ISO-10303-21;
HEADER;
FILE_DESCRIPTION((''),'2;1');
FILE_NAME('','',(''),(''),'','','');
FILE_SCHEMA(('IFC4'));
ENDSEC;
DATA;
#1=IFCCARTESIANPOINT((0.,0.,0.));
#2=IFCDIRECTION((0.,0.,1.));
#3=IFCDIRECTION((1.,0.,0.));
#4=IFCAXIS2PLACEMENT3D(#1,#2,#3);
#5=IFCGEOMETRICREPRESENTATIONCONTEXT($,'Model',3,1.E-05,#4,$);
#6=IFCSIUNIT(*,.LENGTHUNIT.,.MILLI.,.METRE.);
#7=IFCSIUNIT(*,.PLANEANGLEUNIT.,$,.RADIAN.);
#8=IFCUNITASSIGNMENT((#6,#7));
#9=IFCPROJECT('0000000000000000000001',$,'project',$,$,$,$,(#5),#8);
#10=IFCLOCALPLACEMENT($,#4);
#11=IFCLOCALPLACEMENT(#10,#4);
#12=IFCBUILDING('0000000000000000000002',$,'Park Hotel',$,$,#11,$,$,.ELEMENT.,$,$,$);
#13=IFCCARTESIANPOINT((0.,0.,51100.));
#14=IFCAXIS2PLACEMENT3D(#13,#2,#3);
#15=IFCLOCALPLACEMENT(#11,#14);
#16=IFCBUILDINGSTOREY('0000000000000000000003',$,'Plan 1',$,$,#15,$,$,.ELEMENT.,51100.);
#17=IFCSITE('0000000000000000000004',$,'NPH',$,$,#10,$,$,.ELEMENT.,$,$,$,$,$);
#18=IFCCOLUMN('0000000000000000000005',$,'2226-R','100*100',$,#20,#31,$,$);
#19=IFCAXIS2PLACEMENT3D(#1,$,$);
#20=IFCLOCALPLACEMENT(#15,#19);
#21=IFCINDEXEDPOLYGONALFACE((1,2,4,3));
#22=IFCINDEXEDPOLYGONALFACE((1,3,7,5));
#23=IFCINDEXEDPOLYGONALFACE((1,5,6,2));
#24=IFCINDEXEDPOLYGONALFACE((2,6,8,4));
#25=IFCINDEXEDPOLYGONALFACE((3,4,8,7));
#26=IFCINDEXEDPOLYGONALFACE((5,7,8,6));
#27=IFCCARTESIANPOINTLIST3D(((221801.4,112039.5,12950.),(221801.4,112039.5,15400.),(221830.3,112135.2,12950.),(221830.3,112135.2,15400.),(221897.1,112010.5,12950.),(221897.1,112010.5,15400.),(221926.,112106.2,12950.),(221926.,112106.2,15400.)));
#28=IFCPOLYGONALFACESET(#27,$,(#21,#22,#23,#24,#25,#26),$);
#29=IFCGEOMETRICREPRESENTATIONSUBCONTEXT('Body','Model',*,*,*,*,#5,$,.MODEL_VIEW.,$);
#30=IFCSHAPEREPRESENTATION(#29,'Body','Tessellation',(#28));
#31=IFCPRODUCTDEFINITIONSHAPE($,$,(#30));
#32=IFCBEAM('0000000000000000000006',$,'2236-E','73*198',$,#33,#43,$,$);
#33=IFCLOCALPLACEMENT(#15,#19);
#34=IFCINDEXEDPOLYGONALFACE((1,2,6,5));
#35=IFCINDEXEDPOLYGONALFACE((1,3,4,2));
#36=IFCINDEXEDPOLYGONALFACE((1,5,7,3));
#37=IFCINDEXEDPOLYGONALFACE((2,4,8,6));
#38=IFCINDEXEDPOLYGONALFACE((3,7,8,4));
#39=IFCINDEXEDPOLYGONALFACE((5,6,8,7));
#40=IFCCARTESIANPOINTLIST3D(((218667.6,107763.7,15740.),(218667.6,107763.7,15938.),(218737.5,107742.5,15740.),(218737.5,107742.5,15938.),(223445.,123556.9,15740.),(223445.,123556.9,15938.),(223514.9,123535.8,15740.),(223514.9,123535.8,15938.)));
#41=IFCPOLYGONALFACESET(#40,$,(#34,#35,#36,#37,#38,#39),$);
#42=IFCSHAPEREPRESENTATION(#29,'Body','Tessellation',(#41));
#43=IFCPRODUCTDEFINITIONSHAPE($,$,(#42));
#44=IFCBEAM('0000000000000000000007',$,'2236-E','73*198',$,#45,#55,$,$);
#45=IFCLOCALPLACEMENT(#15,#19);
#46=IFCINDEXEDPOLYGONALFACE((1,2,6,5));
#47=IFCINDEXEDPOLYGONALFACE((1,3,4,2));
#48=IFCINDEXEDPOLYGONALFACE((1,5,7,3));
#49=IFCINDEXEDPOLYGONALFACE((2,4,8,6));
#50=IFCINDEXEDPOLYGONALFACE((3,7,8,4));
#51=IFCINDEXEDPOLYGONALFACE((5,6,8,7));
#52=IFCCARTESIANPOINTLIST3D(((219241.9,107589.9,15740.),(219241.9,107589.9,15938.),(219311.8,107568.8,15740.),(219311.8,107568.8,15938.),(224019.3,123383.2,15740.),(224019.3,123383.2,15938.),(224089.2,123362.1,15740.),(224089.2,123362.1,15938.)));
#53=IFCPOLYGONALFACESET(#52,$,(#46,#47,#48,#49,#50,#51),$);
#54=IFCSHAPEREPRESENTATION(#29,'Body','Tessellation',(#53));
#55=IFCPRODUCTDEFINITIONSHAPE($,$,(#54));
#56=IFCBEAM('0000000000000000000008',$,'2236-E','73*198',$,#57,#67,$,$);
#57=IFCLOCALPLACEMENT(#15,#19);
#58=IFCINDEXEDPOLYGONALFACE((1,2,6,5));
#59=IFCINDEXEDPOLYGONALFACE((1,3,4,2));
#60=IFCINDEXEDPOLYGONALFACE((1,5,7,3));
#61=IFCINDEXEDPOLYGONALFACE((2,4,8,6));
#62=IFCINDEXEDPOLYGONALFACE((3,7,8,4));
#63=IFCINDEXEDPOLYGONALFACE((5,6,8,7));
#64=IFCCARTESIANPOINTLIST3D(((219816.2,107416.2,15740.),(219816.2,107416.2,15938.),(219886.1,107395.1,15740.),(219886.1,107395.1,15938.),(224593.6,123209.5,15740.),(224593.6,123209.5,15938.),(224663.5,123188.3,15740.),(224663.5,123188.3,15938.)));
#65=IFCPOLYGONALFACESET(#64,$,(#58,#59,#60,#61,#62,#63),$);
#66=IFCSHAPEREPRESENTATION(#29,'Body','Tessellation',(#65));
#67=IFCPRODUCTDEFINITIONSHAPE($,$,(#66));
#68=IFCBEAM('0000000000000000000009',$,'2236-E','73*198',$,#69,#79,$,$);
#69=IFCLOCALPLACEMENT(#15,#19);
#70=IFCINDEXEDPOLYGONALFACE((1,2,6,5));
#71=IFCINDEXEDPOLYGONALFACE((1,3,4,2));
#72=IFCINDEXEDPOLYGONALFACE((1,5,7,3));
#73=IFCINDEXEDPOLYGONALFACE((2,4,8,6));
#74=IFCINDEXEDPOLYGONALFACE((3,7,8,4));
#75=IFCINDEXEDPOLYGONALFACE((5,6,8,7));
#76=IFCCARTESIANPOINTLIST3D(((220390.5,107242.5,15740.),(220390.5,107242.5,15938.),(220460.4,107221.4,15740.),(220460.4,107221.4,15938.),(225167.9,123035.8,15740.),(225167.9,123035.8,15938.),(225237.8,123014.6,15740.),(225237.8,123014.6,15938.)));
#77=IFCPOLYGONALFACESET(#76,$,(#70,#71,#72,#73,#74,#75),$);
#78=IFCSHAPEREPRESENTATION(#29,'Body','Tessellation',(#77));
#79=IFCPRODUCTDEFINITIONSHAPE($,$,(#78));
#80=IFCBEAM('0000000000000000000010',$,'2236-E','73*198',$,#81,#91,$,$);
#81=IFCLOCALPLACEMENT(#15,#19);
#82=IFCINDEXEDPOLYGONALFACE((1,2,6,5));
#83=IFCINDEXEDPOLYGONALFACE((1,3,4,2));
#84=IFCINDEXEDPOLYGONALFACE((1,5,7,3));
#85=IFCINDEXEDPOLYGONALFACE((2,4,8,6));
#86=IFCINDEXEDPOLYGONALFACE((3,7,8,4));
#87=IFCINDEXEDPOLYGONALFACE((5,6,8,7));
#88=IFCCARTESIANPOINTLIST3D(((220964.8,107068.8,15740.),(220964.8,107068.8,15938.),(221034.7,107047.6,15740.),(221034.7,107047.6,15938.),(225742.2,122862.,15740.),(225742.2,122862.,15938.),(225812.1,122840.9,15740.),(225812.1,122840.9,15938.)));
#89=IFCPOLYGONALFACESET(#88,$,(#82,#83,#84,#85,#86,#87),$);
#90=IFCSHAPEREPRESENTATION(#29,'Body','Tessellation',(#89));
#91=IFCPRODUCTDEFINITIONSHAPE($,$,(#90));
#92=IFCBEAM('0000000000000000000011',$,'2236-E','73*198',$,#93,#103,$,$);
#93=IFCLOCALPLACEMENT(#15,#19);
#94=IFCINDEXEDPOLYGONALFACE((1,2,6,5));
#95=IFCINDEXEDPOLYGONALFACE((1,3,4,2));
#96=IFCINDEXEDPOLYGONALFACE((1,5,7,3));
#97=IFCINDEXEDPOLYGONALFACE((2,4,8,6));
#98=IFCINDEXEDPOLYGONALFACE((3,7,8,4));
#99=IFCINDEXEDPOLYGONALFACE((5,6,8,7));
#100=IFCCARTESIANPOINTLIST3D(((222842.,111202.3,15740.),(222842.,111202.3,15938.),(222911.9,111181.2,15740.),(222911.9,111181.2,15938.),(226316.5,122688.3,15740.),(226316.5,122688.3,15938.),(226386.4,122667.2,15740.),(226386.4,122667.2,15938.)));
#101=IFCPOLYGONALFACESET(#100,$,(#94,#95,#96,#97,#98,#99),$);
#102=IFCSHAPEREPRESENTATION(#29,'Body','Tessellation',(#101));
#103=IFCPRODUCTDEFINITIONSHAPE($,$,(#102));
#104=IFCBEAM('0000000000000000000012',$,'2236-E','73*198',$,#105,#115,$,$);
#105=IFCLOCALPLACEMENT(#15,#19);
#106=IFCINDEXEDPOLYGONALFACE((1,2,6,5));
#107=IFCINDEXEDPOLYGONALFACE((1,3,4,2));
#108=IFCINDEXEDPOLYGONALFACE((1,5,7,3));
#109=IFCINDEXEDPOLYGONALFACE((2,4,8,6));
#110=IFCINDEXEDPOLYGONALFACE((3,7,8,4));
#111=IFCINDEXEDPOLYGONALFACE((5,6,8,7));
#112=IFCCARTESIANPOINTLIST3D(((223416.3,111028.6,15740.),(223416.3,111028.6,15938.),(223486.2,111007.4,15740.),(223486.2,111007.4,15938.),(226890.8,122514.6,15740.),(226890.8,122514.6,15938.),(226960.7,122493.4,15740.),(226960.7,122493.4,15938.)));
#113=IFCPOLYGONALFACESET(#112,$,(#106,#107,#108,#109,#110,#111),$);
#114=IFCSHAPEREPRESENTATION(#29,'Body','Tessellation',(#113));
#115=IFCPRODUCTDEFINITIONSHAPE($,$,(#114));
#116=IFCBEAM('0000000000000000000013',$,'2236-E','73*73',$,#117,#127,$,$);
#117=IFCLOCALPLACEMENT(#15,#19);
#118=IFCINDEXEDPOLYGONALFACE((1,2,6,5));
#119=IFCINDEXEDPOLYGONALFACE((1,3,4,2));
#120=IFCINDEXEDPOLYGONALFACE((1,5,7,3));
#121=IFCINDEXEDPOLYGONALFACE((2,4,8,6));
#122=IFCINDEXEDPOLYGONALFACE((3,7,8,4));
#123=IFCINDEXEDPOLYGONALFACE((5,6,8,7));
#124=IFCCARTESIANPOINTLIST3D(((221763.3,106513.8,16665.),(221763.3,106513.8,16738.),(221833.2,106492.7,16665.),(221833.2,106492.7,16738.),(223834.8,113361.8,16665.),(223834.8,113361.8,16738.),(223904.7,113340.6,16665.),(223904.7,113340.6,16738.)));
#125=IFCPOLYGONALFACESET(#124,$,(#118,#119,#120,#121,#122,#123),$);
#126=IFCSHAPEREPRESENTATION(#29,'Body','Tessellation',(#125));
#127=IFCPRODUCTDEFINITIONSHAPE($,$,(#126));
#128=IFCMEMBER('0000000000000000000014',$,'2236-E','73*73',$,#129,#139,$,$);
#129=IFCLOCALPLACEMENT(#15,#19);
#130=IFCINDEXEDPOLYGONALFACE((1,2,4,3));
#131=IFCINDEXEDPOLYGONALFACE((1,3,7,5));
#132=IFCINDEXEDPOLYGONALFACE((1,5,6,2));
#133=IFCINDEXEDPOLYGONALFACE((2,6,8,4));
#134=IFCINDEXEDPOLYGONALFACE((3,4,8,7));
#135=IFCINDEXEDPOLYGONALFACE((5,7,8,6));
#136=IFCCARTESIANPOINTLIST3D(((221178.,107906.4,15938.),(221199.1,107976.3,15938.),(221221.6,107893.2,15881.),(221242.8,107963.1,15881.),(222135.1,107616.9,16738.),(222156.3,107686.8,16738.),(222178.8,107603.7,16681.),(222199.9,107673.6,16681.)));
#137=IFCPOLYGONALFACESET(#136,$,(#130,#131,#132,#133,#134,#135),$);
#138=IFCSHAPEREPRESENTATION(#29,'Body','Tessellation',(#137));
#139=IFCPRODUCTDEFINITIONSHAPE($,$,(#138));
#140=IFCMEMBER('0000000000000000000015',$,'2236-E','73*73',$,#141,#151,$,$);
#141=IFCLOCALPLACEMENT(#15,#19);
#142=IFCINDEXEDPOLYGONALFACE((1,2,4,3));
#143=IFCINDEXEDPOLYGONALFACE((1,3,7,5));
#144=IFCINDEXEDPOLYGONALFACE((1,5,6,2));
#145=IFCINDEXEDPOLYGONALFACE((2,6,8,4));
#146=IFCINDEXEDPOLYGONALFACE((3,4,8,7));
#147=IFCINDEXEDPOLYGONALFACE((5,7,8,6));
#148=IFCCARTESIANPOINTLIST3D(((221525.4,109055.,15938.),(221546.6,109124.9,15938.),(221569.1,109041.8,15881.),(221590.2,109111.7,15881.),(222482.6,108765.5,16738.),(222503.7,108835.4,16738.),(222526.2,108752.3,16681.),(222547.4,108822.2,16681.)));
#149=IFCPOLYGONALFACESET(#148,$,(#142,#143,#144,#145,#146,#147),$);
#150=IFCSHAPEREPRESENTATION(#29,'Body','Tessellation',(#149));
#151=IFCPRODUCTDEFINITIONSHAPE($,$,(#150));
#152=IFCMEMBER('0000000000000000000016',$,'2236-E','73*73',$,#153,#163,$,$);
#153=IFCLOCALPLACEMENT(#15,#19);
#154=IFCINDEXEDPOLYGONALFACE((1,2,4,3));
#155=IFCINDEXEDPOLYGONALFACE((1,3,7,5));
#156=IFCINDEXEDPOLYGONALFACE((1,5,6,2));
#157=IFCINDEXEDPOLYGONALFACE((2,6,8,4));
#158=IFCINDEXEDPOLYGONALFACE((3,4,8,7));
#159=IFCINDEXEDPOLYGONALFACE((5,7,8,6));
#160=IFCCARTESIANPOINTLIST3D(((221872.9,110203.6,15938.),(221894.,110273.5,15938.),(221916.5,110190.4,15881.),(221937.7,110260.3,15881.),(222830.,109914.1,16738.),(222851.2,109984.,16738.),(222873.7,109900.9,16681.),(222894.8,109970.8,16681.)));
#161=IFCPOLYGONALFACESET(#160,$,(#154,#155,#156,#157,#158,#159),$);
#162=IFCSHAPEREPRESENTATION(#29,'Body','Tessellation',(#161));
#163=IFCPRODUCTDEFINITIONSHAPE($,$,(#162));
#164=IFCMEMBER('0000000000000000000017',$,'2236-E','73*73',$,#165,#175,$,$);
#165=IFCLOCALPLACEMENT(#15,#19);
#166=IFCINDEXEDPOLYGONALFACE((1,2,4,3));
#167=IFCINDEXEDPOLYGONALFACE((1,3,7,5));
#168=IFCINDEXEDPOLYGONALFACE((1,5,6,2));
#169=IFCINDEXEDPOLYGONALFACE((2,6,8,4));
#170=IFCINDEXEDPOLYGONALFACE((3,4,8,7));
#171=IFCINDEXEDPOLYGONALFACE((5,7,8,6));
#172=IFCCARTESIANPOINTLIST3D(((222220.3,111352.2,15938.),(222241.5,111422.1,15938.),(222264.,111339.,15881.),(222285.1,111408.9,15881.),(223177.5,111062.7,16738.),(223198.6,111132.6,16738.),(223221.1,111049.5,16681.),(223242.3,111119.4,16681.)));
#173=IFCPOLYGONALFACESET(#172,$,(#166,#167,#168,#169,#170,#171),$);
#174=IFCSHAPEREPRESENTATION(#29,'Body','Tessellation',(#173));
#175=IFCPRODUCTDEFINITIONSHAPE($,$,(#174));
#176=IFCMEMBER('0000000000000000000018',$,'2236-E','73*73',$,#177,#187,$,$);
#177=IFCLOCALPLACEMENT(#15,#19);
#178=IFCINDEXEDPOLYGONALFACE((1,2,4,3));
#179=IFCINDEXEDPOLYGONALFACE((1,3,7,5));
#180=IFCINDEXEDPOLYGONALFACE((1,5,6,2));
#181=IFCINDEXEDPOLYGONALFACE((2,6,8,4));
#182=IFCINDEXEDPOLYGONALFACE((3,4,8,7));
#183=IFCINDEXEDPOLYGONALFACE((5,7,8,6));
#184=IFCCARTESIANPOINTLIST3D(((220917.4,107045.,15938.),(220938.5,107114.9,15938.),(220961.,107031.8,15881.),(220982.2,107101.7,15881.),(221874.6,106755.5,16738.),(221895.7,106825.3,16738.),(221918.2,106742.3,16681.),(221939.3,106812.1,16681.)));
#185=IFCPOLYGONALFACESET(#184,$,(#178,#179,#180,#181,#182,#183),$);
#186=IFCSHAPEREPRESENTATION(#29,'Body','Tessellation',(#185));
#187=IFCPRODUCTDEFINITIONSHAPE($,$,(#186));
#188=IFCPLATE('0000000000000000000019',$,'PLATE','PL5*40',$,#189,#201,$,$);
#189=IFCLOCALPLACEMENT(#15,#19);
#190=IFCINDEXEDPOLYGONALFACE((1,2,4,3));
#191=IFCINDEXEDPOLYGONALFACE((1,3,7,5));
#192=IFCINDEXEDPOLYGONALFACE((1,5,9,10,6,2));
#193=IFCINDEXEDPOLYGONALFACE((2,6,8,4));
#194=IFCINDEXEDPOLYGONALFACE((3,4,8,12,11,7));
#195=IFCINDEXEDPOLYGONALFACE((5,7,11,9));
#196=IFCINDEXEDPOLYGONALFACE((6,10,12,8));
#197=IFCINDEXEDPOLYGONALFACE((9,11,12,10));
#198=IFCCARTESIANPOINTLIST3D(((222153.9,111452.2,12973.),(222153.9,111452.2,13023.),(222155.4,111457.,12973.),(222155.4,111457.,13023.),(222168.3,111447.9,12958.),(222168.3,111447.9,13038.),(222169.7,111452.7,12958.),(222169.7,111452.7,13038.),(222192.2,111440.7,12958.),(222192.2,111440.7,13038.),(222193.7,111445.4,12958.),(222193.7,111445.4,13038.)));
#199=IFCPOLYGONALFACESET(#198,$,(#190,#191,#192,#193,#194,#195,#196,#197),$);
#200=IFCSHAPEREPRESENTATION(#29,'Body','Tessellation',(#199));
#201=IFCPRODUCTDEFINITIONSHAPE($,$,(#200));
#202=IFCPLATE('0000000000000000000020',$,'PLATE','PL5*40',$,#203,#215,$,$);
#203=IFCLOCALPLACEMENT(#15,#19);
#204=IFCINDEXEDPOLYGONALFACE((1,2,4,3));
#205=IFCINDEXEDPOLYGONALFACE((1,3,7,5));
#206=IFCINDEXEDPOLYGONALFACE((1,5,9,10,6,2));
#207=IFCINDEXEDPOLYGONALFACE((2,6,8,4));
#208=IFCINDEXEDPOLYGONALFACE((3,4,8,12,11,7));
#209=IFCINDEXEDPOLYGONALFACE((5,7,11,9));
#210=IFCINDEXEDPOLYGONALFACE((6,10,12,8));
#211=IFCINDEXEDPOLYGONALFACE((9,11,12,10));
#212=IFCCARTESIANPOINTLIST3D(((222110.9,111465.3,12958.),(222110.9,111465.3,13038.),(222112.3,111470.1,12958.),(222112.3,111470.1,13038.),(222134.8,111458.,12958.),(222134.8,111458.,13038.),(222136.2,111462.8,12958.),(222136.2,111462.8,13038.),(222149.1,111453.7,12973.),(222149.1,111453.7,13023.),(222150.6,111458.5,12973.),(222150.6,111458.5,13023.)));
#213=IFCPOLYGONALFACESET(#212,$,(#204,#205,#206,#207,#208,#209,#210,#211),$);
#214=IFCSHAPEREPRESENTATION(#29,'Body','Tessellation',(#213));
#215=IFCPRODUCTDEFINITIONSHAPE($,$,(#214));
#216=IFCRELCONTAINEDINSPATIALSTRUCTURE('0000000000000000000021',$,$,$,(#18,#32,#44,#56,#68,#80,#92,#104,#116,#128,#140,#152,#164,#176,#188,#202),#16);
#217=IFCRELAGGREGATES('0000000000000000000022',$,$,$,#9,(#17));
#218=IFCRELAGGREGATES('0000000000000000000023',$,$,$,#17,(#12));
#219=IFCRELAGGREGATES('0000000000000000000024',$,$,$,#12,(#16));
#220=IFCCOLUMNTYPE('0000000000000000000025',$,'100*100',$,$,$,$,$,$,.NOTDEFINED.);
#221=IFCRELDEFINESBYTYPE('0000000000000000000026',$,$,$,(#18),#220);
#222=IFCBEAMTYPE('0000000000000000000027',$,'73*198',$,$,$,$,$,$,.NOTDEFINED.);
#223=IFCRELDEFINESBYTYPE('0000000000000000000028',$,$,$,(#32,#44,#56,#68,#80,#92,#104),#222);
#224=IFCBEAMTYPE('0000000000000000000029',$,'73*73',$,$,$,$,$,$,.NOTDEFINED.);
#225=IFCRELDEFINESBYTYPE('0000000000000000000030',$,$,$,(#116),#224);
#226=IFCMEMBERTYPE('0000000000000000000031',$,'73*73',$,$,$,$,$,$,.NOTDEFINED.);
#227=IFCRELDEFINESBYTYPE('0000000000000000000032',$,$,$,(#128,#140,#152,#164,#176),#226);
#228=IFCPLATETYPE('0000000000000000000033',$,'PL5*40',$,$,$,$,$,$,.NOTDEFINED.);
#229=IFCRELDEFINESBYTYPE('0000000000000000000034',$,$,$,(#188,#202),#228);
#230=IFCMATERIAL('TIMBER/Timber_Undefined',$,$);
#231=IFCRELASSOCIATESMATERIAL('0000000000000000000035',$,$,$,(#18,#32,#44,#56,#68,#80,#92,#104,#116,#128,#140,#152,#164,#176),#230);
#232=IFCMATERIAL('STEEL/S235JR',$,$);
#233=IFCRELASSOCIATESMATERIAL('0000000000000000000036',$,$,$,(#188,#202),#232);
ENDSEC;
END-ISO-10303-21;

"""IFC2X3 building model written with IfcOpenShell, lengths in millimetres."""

from ifc_helpers import new_model, si_unit, frame, origin_with_axes, origin_2d_with_axis, place, context, subcontext, project, spatial, polyline, rectangle, outline, extrude, material, type_object, element, save


model = new_model("IFC2X3")

# Units and contexts
model_context = context("Model", 3, precision=1e-05, world=origin_with_axes())
body_context = subcontext(model_context, "Body", "Model", "MODEL_VIEW")
ifc_project = project(units=[si_unit("LENGTHUNIT", "METRE", prefix="MILLI"), si_unit("PLANEANGLEUNIT", "RADIAN")], contexts=[model_context])

# Site, building, storey
site_placement = place(None, origin_with_axes())
site = spatial("IfcSite", under=ifc_project, at=site_placement, Name="NPH", CompositionType="ELEMENT")
building_placement = place(site_placement, origin_with_axes())
building = spatial("IfcBuilding", under=site, at=building_placement, Name="Park Hotel", CompositionType="ELEMENT")
storey_placement = place(building_placement, frame((0.0, 0.0, 51100.0), z_axis=(0.0, 0.0, 1.0), x_axis=(1.0, 0.0, 0.0)))
storey = spatial("IfcBuildingStorey", under=building, at=storey_placement, Name="Plan 1", CompositionType="ELEMENT", Elevation=51100.0)

# Column
ifc_material_1 = material(Name="TIMBER/Timber_Undefined")
column_type = type_object("IfcColumnType", Name="100*100", PredefinedType="NOTDEFINED")
column_placement = place(storey_placement, frame((221863.7, 112072.9, 15400.0), z_axis=(0.0, 0.0, -1.0), x_axis=(0.289538, 0.957167, 0.0)))
element("IfcColumn", 1, at=column_placement, inside=storey, type_object=column_type, material=ifc_material_1, Name="2226-R", Description="100*100", context=body_context, shape_type="SweptSolid", body=[
    extrude(rectangle(XDim=100.0, YDim=100.0, at=origin_2d_with_axis()), frame((0.0, 0.0, 2450.0), z_axis=(0.0, 0.0, -1.0), x_axis=(0.0, 1.0, 0.0)), (0.0, 0.0, 1.0), 2450.0),
])

# Beams
beam_type_1 = type_object("IfcBeamType", Name="73*198", PredefinedType="NOTDEFINED")
for number, where, z_axis, x_axis, name in (
    (2, (218702.6, 107753.1, 15839.0), (-0.957167, 0.289538, 0.0), (0.289538, 0.957167, 0.0), "2236-E"),
    (3, (219276.9, 107579.4, 15839.0), (-0.957167, 0.289538, 0.0), (0.289538, 0.957167, 0.0), "2236-E"),
    (4, (219851.2, 107405.7, 15839.0), (-0.957167, 0.289538, 0.0), (0.289538, 0.957167, 0.0), "2236-E"),
    (5, (220425.5, 107231.9, 15839.0), (-0.957167, 0.289538, 0.0), (0.289538, 0.957167, 0.0), "2236-E"),
    (6, (220999.8, 107058.2, 15839.0), (-0.957167, 0.289538, 0.0), (0.289538, 0.957167, 0.0), "2236-E"),
):
    element("IfcBeam", number, at=place(storey_placement, frame(where, z_axis=z_axis, x_axis=x_axis)), inside=storey, type_object=beam_type_1, material=ifc_material_1, Name=name, Description="73*198", context=body_context, shape_type="SweptSolid", body=[
        extrude(rectangle(XDim=198.0, YDim=73.0, at=origin_2d_with_axis()), frame((16500.0, 0.0, 0.0), z_axis=(-1.0, 0.0, 0.0), x_axis=(0.0, -1.0, 0.0)), (0.0, 0.0, 1.0), 16500.0),
    ])
for number, where, z_axis, x_axis, name in (
    (7, (222877.0, 111191.7, 15839.0), (-0.957167, 0.289538, 0.0), (0.289538, 0.957167, 0.0), "2236-E"),
    (8, (223451.3, 111018.0, 15839.0), (-0.957167, 0.289538, 0.0), (0.289538, 0.957167, 0.0), "2236-E"),
):
    element("IfcBeam", number, at=place(storey_placement, frame(where, z_axis=z_axis, x_axis=x_axis)), inside=storey, type_object=beam_type_1, material=ifc_material_1, Name=name, Description="73*198", context=body_context, shape_type="SweptSolid", body=[
        extrude(rectangle(XDim=198.0, YDim=73.0, at=origin_2d_with_axis()), frame((12000.0, 0.0, 0.0), z_axis=(-1.0, 0.0, 0.0), x_axis=(0.0, -1.0, 0.0)), (0.0, 0.0, 1.0), 12000.0),
    ])
beam_type_2 = type_object("IfcBeamType", Name="73*73", PredefinedType="NOTDEFINED")
beam_placement = place(storey_placement, frame((221798.3, 106503.2, 16701.5), z_axis=(-0.957167, 0.289538, 0.0), x_axis=(0.289538, 0.957167, 0.0)))
element("IfcBeam", 9, at=beam_placement, inside=storey, type_object=beam_type_2, material=ifc_material_1, Name="2236-E", Description="73*73", context=body_context, shape_type="SweptSolid", body=[
    extrude(rectangle(XDim=73.0, YDim=73.0, at=origin_2d_with_axis()), frame((7154.4, 0.0, 0.0), z_axis=(-1.0, 0.0, 0.0), x_axis=(0.0, -1.0, 0.0)), (0.0, 0.0, 1.0), 7154.4),
])

# Members
member_type = type_object("IfcMemberType", Name="73*73", PredefinedType="NOTDEFINED")
for number, where, z_axis, x_axis, name in (
    (10, (222167.5, 107645.2, 16709.5), (0.289538, 0.957167, 0.0), (-0.747421, 0.226091, -0.624695), "2236-E"),
    (11, (222515.0, 108793.8, 16709.5), (0.289538, 0.957167, 0.0), (-0.747421, 0.226091, -0.624695), "2236-E"),
    (12, (222862.4, 109942.4, 16709.5), (0.289538, 0.957167, 0.0), (-0.747421, 0.226091, -0.624695), "2236-E"),
    (13, (223209.9, 111091.0, 16709.5), (0.289538, 0.957167, 0.0), (-0.747421, 0.226091, -0.624695), "2236-E"),
    (14, (221907.0, 106783.8, 16709.5), (0.289538, 0.957167, 0.0), (-0.747421, 0.226091, -0.624695), "2236-E"),
):
    element("IfcMember", number, at=place(storey_placement, frame(where, z_axis=z_axis, x_axis=x_axis)), inside=storey, type_object=member_type, material=ifc_material_1, Name=name, Description="73*73", context=body_context, shape_type="SweptSolid", body=[
        extrude(rectangle(XDim=73.0, YDim=73.0, at=origin_2d_with_axis()), frame((1280.6, 0.0, 0.0), z_axis=(-1.0, 0.0, 0.0), x_axis=(0.0, -1.0, 0.0)), (0.0, 0.0, 1.0), 1280.6),
    ])

# Plates
ifc_material_2 = material(Name="STEEL/S235JR")
plate_type = type_object("IfcPlateType", Name="PL5*40", PredefinedType="NOTDEFINED")
plate_1_placement = place(storey_placement, frame((222192.9, 111443.1, 12958.0), z_axis=(0.289538, 0.957167, 0.0), x_axis=(-0.957167, 0.289538, 0.0)))
element("IfcPlate", 15, at=plate_1_placement, inside=storey, type_object=plate_type, material=ifc_material_2, Name="PLATE", Description="PL5*40", context=body_context, shape_type="SweptSolid", body=[
    extrude(outline(polyline([(0.0, 0.0), (25.0, 0.0), (40.0, 15.0), (40.0, 65.0), (25.0, 80.0), (0.0, 80.0), (0.0, 0.0)])), frame((0.0, 0.0, -2.5), z_axis=(0.0, 0.0, 1.0), x_axis=(1.0, 0.0, 0.0)), (0.0, 0.0, 1.0), 5.0),
])
plate_2_placement = place(storey_placement, frame((222149.9, 111456.1, 12958.0), z_axis=(0.289538, 0.957167, 0.0), x_axis=(-0.957167, 0.289538, 0.0)))
element("IfcPlate", 16, at=plate_2_placement, inside=storey, type_object=plate_type, material=ifc_material_2, Name="PLATE", Description="PL5*40", context=body_context, shape_type="SweptSolid", body=[
    extrude(outline(polyline([(0.0, 15.0), (15.0, 0.0), (40.0, 0.0), (40.0, 80.0), (15.0, 80.0), (0.0, 65.0), (0.0, 15.0)])), frame((0.0, 0.0, -2.5), z_axis=(0.0, 0.0, 1.0), x_axis=(1.0, 0.0, 0.0)), (0.0, 0.0, 1.0), 5.0),
])

save(model, "model.ifc")
